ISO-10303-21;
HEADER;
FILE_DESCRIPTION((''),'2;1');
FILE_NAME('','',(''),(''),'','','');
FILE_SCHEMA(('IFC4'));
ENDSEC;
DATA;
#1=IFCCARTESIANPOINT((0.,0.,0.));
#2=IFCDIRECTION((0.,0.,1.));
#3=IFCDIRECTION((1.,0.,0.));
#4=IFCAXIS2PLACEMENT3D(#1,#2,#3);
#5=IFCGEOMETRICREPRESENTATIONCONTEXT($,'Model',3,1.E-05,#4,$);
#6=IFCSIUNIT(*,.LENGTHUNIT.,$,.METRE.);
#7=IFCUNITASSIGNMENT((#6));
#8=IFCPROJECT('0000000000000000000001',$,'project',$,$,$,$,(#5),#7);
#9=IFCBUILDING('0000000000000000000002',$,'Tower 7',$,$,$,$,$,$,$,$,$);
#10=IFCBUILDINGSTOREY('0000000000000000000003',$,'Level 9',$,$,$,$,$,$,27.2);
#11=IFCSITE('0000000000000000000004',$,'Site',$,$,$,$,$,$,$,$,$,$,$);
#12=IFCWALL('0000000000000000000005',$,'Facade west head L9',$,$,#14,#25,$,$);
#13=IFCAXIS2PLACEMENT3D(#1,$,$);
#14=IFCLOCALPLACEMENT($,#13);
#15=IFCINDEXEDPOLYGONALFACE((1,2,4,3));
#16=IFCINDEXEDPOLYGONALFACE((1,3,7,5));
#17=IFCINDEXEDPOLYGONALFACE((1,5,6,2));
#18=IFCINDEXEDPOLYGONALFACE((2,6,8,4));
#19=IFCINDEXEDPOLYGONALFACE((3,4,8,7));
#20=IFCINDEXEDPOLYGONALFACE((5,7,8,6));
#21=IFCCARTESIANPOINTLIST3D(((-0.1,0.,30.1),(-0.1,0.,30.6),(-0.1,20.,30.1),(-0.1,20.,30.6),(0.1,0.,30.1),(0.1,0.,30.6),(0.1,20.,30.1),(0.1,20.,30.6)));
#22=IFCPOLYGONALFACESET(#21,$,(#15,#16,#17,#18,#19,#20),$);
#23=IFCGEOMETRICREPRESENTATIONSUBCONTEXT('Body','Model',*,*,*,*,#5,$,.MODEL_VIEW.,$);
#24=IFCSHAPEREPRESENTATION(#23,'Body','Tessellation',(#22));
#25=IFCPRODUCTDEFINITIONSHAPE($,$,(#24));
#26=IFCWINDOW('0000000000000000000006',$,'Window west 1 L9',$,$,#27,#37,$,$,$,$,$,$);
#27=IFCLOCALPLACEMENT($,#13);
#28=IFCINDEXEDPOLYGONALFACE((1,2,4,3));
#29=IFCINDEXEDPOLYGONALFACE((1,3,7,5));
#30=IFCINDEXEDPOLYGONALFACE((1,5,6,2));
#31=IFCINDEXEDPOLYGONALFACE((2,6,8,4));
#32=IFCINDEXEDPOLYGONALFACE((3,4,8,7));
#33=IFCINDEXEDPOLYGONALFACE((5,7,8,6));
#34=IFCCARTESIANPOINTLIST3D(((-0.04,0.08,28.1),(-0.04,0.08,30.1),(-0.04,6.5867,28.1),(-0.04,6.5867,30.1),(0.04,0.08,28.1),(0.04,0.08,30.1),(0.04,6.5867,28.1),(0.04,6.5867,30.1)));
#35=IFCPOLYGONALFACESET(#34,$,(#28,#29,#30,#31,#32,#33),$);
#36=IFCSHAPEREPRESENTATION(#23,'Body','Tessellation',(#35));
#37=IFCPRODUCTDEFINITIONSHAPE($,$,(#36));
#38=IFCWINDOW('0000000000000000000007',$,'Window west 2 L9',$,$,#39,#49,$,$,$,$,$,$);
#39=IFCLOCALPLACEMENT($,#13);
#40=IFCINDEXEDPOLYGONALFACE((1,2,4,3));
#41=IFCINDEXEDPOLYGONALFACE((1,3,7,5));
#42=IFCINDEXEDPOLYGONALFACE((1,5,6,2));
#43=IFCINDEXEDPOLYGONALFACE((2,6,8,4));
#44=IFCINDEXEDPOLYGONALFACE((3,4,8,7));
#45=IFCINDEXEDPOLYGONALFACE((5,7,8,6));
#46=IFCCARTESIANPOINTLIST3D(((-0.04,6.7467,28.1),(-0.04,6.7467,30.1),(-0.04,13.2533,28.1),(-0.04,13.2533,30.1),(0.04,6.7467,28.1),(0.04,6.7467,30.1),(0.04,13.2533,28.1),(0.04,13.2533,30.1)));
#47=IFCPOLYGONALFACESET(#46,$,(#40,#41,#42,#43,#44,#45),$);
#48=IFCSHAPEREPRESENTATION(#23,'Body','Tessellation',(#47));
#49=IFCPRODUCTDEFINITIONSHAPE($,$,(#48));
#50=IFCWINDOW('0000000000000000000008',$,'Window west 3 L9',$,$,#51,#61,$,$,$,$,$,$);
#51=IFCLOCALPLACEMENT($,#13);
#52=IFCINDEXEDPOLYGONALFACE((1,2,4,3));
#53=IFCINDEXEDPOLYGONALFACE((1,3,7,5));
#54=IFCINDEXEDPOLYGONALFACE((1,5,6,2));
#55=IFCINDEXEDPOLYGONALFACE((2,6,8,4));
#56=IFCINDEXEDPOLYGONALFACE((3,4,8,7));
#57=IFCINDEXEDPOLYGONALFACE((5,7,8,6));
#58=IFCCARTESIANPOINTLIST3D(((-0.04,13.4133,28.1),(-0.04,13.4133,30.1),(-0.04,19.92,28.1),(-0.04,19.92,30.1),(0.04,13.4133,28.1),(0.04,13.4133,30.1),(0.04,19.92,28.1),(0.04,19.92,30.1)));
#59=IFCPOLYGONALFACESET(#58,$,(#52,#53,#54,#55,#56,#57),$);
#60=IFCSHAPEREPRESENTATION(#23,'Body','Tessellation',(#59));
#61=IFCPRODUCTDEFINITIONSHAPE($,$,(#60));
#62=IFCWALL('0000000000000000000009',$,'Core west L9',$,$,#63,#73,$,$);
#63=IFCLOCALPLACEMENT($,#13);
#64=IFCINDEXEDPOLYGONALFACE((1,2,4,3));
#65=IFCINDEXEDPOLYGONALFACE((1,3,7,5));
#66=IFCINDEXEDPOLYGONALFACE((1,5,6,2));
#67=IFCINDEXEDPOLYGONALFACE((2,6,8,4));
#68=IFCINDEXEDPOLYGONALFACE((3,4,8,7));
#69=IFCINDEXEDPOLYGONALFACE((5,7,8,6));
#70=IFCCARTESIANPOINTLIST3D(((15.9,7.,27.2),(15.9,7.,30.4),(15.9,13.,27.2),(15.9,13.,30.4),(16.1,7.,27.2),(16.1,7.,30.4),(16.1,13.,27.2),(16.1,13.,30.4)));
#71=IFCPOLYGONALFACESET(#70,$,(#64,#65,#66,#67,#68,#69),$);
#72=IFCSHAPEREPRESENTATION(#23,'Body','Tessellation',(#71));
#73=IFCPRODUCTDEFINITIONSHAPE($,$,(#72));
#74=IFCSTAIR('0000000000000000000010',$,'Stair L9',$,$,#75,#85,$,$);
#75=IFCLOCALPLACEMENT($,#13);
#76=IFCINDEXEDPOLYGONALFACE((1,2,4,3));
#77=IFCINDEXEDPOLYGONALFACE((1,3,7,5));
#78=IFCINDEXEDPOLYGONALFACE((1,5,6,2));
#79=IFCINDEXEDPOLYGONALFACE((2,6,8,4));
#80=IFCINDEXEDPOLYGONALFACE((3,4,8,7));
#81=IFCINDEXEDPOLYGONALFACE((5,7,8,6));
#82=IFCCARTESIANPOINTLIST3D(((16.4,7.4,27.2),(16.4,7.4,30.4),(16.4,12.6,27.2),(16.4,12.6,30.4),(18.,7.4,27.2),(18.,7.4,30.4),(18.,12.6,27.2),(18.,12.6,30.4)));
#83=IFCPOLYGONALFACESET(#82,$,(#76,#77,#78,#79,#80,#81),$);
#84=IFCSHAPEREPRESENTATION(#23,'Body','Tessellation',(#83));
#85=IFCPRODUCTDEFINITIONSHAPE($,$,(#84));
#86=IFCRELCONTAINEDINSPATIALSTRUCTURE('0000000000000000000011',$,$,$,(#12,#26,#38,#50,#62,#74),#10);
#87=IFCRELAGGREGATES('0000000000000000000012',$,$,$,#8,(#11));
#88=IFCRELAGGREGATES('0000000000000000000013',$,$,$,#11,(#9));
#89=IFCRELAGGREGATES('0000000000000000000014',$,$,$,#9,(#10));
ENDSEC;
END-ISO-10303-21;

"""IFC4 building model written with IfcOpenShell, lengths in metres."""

from ifc_helpers import new_model, si_unit, frame, origin, origin_with_axes, origin_2d, place, context, subcontext, project, spatial, rectangle, extrude, element, save


model = new_model("IFC4")

# Units and contexts
model_context = context("Model", 3, precision=1e-05, world=origin_with_axes())
body_context = subcontext(model_context, "Body", "Model", "MODEL_VIEW")
ifc_project = project(units=[si_unit("LENGTHUNIT", "METRE")], contexts=[model_context])

# Site, building, storey
site = spatial("IfcSite", under=ifc_project, Name="Site")
building = spatial("IfcBuilding", under=site, Name="Tower 7")
storey = spatial("IfcBuildingStorey", under=building, Name="Level 9", Elevation=27.2)

# Wall
wall_1_placement = place(None, frame((0.0, 10.0, 30.1), z_axis=(0.0, 0.0, 1.0), x_axis=(1.0, 0.0, 0.0)))
element("IfcWall", 1, at=wall_1_placement, inside=storey, Name="Facade west head L9", context=body_context, shape_type="SweptSolid", body=[
    extrude(rectangle(XDim=0.2, YDim=20.0, at=origin_2d()), origin(), (0.0, 0.0, 1.0), 0.5),
])

# Windows
for number, where, z_axis, x_axis, name in (
    (2, (0.0, 3.3333, 28.1), (0.0, 0.0, 1.0), (1.0, 0.0, 0.0), "Window west 1 L9"),
    (3, (0.0, 10.0, 28.1), (0.0, 0.0, 1.0), (1.0, 0.0, 0.0), "Window west 2 L9"),
):
    element("IfcWindow", number, at=place(None, frame(where, z_axis=z_axis, x_axis=x_axis)), inside=storey, Name=name, context=body_context, shape_type="SweptSolid", body=[
        extrude(rectangle(XDim=0.08, YDim=6.5067, at=origin_2d()), origin(), (0.0, 0.0, 1.0), 2.0),
    ])
window_1_placement = place(None, frame((0.0, 16.6667, 28.1), z_axis=(0.0, 0.0, 1.0), x_axis=(1.0, 0.0, 0.0)))
element("IfcWindow", 4, at=window_1_placement, inside=storey, Name="Window west 3 L9", context=body_context, shape_type="SweptSolid", body=[
    extrude(rectangle(XDim=0.08, YDim=6.5067, at=origin_2d()), origin(), (0.0, 0.0, 1.0), 2.0),
])

# Wall
wall_2_placement = place(None, frame((16.0, 10.0, 27.2), z_axis=(0.0, 0.0, 1.0), x_axis=(1.0, 0.0, 0.0)))
element("IfcWall", 5, at=wall_2_placement, inside=storey, Name="Core west L9", context=body_context, shape_type="SweptSolid", body=[
    extrude(rectangle(XDim=0.2, YDim=6.0, at=origin_2d()), origin(), (0.0, 0.0, 1.0), 3.2),
])

# Stair
stair_placement = place(None, frame((17.2, 10.0, 27.2), z_axis=(0.0, 0.0, 1.0), x_axis=(1.0, 0.0, 0.0)))
element("IfcStair", 6, at=stair_placement, inside=storey, Name="Stair L9", context=body_context, shape_type="SweptSolid", body=[
    extrude(rectangle(XDim=1.6, YDim=5.2, at=origin_2d()), origin(), (0.0, 0.0, 1.0), 3.2),
])

save(model, "model.ifc")
